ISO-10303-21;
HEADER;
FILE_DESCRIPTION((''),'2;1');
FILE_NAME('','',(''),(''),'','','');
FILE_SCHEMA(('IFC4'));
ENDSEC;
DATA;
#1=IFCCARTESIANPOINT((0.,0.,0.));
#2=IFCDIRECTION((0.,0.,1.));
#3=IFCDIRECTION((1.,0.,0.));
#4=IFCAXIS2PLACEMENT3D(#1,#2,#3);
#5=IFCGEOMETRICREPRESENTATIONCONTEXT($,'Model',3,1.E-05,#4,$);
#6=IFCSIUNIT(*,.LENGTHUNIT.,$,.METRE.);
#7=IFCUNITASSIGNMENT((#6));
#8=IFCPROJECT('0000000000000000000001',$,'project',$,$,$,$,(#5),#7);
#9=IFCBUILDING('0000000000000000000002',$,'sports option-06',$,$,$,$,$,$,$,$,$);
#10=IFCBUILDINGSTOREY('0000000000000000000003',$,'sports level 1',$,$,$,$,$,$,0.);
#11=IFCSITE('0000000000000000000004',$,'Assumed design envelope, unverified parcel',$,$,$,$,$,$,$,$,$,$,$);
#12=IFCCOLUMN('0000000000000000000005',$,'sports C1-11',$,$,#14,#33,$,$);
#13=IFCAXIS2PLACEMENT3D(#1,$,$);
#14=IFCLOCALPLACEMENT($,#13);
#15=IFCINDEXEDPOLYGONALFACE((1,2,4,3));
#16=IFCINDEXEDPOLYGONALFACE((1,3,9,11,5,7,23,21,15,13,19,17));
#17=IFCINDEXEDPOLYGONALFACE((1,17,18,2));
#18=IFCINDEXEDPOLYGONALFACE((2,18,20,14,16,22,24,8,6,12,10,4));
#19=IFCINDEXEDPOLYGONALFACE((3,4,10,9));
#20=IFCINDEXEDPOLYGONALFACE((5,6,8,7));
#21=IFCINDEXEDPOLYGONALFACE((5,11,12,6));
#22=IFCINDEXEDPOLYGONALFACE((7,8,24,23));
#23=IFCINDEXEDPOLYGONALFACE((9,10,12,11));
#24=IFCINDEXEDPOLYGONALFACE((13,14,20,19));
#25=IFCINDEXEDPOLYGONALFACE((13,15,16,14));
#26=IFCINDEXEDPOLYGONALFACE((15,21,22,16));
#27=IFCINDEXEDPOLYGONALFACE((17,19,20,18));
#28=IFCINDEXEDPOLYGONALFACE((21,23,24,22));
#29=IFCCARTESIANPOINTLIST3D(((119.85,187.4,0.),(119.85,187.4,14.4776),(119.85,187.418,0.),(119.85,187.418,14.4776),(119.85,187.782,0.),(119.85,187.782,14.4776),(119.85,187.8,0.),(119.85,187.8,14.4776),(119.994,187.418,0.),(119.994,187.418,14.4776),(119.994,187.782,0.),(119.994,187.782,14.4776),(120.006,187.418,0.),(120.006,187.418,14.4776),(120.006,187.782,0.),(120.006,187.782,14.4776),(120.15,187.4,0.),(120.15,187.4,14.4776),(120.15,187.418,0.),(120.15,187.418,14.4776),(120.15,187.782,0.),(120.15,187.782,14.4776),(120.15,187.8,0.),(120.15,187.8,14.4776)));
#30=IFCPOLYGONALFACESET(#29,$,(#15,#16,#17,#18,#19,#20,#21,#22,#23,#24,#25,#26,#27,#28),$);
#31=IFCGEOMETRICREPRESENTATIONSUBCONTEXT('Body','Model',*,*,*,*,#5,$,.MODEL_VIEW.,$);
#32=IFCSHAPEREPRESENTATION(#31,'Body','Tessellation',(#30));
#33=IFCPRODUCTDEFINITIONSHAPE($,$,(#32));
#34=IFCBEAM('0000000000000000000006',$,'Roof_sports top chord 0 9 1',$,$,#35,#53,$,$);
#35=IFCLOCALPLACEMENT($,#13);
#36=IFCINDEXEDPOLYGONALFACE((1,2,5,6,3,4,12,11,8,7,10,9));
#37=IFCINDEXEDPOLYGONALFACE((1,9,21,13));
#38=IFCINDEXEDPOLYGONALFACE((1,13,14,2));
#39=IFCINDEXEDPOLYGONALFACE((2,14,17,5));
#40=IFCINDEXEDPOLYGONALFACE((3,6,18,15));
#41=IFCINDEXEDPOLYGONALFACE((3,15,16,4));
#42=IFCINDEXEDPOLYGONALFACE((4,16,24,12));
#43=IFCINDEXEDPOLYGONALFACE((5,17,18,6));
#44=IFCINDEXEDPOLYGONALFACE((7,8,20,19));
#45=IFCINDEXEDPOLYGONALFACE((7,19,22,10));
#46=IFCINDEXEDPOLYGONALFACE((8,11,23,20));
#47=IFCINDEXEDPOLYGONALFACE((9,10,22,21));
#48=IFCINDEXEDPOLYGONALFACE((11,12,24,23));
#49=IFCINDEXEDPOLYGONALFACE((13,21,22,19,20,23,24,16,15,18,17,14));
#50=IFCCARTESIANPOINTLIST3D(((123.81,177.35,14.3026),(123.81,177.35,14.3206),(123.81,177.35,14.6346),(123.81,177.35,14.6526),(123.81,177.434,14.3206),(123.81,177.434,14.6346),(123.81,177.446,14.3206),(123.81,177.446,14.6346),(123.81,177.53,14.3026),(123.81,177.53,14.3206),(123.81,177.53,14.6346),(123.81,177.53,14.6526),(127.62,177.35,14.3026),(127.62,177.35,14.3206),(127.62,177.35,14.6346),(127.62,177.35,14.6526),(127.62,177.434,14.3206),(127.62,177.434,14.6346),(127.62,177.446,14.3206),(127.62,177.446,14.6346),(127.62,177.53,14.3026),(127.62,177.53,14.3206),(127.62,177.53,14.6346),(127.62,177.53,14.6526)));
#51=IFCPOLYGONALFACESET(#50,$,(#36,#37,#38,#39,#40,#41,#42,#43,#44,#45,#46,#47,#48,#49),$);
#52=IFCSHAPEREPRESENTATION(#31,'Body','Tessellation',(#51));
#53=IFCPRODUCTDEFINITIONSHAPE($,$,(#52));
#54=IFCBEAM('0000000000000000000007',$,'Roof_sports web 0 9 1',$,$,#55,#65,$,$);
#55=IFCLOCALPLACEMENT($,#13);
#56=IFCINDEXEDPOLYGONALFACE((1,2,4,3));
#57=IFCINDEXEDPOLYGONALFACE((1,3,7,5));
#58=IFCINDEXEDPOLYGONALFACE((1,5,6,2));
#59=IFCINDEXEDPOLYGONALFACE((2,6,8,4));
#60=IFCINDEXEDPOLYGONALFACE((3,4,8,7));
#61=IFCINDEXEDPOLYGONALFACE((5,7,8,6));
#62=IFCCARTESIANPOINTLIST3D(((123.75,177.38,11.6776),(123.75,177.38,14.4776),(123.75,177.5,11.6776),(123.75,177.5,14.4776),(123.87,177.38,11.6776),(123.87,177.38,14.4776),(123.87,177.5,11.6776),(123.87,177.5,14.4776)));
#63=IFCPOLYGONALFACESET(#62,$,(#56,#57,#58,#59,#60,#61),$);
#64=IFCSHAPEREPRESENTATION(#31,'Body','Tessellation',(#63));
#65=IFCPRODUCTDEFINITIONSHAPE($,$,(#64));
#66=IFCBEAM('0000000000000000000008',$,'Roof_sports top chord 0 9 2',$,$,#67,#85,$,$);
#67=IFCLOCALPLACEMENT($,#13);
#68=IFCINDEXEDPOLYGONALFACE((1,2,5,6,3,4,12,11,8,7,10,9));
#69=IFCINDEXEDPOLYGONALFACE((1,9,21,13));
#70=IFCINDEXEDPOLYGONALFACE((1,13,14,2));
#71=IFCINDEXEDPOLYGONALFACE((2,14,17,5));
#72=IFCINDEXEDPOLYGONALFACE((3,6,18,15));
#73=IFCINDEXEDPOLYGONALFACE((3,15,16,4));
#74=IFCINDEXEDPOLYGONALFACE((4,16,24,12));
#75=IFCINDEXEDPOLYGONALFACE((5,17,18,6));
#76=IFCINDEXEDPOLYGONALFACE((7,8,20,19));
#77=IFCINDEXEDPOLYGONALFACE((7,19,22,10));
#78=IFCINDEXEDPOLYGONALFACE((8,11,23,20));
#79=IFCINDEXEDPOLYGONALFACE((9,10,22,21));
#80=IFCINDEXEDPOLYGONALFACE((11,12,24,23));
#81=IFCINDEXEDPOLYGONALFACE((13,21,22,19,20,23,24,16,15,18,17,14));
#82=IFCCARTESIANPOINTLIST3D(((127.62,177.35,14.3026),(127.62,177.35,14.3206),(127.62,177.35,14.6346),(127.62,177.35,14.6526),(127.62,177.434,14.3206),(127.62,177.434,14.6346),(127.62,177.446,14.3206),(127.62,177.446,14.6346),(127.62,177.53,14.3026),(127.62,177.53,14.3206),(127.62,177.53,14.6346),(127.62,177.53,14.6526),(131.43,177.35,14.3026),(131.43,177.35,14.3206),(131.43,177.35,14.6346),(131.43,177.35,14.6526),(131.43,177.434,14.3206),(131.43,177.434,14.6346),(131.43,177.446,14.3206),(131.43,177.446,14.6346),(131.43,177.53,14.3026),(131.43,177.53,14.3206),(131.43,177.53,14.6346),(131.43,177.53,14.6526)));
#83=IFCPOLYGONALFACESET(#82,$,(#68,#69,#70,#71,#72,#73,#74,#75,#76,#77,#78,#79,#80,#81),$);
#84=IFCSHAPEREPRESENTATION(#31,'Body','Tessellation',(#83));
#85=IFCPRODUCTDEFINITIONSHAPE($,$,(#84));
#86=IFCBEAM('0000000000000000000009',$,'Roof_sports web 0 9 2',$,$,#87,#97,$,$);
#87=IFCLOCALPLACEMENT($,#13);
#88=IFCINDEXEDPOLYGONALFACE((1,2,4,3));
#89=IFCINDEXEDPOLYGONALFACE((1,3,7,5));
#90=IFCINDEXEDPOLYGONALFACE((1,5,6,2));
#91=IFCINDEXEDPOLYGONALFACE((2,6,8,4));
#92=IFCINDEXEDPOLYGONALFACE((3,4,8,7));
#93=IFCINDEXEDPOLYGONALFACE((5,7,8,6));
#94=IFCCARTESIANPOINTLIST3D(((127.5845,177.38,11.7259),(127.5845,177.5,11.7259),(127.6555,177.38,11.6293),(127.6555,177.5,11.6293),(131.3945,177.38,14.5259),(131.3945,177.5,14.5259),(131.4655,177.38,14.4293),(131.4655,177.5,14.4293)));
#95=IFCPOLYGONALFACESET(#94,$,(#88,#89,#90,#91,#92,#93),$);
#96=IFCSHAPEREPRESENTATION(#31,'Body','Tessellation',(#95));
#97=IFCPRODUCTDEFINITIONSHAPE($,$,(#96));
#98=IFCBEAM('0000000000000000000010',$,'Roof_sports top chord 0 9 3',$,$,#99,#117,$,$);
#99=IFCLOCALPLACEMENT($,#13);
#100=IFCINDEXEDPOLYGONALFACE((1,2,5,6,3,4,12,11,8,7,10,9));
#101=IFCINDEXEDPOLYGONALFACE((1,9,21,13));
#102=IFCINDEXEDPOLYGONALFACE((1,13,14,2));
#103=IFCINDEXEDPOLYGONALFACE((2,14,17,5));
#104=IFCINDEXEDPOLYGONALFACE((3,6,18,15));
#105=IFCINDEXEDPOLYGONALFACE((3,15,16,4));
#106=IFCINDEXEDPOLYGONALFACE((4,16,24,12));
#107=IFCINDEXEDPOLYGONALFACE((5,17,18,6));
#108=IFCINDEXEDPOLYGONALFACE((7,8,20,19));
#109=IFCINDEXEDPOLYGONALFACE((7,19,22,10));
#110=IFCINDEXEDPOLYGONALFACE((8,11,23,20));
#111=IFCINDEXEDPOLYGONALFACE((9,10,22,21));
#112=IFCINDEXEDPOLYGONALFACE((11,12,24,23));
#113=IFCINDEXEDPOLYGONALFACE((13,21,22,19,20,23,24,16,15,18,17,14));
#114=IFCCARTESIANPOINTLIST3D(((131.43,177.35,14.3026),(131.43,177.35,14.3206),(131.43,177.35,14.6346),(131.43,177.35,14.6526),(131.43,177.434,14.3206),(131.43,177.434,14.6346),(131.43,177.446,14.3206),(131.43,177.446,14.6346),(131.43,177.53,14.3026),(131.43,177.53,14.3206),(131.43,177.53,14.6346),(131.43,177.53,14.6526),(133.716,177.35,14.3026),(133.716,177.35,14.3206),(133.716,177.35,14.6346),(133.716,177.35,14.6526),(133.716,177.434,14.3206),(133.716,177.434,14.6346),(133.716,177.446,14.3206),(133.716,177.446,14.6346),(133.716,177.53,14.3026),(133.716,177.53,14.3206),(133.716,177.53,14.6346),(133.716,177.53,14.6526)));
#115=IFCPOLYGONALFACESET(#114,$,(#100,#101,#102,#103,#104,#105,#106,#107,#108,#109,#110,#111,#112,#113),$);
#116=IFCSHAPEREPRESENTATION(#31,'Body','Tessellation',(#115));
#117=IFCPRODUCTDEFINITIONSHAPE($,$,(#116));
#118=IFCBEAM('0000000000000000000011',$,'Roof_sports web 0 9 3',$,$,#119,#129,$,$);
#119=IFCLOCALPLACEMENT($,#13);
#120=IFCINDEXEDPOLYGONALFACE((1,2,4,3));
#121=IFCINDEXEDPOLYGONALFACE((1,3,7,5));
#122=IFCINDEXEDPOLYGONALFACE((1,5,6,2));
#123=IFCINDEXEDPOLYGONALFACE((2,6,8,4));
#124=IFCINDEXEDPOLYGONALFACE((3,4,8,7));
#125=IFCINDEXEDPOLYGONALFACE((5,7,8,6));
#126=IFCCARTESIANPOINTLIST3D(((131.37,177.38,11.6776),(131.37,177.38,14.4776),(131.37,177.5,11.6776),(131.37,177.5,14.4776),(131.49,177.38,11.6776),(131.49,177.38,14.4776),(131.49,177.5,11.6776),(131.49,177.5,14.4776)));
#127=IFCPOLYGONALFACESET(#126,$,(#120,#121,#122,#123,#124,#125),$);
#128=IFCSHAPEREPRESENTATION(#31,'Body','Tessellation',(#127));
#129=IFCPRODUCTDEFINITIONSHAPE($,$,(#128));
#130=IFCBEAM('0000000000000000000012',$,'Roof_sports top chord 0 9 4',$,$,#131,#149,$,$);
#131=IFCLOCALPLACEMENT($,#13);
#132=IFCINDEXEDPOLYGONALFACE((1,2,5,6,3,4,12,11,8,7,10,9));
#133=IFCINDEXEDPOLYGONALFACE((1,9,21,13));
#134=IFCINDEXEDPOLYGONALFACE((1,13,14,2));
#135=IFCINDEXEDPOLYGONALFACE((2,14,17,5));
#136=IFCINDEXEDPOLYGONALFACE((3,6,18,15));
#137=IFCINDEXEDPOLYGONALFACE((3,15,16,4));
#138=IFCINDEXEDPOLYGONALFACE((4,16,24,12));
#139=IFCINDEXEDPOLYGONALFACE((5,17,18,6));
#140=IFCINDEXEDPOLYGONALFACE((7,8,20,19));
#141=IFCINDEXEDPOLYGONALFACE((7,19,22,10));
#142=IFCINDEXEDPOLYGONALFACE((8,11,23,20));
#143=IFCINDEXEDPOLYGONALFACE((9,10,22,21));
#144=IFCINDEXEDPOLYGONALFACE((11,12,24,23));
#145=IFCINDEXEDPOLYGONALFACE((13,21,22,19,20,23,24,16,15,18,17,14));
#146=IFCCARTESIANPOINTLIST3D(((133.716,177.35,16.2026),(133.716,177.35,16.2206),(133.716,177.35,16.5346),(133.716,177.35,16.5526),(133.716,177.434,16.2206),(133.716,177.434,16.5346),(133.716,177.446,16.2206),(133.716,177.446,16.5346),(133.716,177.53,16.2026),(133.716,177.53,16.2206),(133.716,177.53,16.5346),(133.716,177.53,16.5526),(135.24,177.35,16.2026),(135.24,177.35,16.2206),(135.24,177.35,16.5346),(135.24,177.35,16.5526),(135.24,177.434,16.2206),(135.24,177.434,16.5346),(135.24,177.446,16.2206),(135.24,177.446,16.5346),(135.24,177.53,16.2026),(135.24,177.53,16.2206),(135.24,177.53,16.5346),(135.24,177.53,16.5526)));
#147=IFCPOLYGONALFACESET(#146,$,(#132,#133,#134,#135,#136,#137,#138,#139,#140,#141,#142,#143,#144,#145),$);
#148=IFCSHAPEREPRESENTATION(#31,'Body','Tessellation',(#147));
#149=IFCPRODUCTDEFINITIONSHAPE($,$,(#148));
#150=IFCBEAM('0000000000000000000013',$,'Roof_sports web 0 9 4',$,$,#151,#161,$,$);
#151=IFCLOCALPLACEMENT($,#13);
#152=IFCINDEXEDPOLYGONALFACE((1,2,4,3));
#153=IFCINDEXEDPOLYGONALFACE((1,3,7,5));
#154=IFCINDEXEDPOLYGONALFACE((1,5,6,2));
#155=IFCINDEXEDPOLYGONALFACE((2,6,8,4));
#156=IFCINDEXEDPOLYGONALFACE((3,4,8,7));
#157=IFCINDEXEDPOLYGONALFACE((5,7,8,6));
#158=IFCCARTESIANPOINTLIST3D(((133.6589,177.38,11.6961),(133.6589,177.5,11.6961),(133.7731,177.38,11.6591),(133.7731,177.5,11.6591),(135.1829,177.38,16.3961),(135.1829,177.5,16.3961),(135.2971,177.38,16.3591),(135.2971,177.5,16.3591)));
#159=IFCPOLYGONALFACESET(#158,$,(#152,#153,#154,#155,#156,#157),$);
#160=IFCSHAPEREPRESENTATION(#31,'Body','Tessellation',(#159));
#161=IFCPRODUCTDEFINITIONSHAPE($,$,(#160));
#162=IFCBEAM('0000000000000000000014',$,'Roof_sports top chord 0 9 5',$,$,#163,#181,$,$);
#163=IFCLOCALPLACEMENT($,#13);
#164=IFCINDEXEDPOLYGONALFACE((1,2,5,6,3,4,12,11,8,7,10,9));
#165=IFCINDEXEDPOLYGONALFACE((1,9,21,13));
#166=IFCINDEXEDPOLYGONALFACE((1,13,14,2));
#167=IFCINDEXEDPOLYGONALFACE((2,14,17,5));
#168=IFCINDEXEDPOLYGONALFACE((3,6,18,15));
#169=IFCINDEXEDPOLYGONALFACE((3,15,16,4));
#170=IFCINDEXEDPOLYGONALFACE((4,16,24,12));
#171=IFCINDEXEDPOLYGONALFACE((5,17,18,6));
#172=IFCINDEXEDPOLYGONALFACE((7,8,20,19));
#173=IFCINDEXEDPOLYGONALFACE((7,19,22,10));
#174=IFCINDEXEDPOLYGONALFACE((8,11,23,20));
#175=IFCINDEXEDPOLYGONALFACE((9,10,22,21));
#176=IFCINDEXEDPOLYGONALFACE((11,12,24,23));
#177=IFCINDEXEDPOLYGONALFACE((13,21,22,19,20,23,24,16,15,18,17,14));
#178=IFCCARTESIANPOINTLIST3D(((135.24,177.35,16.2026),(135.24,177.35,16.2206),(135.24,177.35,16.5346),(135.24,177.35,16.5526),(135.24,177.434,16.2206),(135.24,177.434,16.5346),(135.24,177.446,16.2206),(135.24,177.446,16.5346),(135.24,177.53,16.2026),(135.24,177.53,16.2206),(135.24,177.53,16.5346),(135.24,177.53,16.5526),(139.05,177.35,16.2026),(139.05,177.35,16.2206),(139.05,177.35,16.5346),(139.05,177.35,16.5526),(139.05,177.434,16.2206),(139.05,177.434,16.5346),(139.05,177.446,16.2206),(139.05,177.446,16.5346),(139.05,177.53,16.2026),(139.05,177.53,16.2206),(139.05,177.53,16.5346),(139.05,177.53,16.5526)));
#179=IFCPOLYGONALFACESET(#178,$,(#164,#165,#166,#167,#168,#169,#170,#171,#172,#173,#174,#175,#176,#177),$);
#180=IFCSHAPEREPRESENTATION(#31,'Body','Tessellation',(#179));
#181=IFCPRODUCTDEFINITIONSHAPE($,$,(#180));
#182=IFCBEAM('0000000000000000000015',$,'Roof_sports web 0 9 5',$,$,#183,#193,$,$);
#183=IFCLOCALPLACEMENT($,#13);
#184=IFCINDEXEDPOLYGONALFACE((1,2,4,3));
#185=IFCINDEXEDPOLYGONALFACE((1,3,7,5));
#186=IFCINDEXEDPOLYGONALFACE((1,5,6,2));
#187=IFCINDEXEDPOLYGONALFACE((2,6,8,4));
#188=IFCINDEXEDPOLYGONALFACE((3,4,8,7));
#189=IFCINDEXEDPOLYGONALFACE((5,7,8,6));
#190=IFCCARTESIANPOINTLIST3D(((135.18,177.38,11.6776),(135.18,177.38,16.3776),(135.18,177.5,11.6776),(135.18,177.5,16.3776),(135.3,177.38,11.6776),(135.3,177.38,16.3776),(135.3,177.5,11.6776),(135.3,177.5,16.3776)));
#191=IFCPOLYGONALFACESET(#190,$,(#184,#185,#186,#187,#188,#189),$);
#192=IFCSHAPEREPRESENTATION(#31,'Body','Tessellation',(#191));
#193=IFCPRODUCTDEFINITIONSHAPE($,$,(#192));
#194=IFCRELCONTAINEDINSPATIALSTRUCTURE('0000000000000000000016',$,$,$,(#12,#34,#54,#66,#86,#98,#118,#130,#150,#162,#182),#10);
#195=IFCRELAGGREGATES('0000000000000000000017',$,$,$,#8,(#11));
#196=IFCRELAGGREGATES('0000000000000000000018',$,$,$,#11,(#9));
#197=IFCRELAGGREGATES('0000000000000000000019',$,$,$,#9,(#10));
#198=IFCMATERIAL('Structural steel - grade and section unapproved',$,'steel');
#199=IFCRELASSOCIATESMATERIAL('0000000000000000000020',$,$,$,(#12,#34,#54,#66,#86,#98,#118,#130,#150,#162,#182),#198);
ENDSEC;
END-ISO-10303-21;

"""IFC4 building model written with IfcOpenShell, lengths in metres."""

from ifc_helpers import new_model, si_unit, frame, origin_with_axes, place, context, subcontext, project, spatial, rectangle, i_section, extrude, material, element, save


model = new_model("IFC4")

# Units and contexts
model_context = context("Model", 3, precision=1e-05, world=origin_with_axes())
body_context = subcontext(model_context, "Body", "Model", "MODEL_VIEW")
ifc_project = project(units=[si_unit("LENGTHUNIT", "METRE")], contexts=[model_context])

# Site, building, storey
site = spatial("IfcSite", under=ifc_project, Name="Assumed design envelope, unverified parcel")
building = spatial("IfcBuilding", under=site, Name="sports option-06")
storey = spatial("IfcBuildingStorey", under=building, Name="sports level 1", Elevation=0.0)

# Column
ifc_material_1 = material(Name="Structural steel - grade and section unapproved", Category="steel")
column_placement = place(None, frame((120.0, 187.6, 0.0), z_axis=(0.0, 0.0, 1.0), x_axis=(-1.0, 0.0, 0.0)))
element("IfcColumn", 1, at=column_placement, inside=storey, material=ifc_material_1, Name="sports C1-11", context=body_context, shape_type="SweptSolid", body=[
    extrude(i_section(OverallWidth=0.3, OverallDepth=0.4, WebThickness=0.012, FlangeThickness=0.018, FilletRadius=0.0), origin_with_axes(), (0.0, 0.0, 1.0), 14.4776),
])

# Beams
beam_1_placement = place(None, frame((123.81, 177.44, 14.4776), z_axis=(1.0, 0.0, 0.0), x_axis=(0.0, 1.0, 0.0)))
element("IfcBeam", 2, at=beam_1_placement, inside=storey, material=ifc_material_1, Name="Roof_sports top chord 0 9 1", context=body_context, shape_type="SweptSolid", body=[
    extrude(i_section(OverallWidth=0.18, OverallDepth=0.35, WebThickness=0.012, FlangeThickness=0.018, FilletRadius=0.0), origin_with_axes(), (0.0, 0.0, 1.0), 3.81),
])
beam_2_placement = place(None, frame((123.81, 177.44, 11.6776), z_axis=(0.0, 0.0, 1.0), x_axis=(-1.0, 0.0, 0.0)))
element("IfcBeam", 3, at=beam_2_placement, inside=storey, material=ifc_material_1, Name="Roof_sports web 0 9 1", context=body_context, shape_type="SweptSolid", body=[
    extrude(rectangle(XDim=0.12, YDim=0.12), origin_with_axes(), (0.0, 0.0, 1.0), 2.8),
])
beam_3_placement = place(None, frame((127.62, 177.44, 14.4776), z_axis=(1.0, 0.0, 0.0), x_axis=(0.0, 1.0, 0.0)))
element("IfcBeam", 4, at=beam_3_placement, inside=storey, material=ifc_material_1, Name="Roof_sports top chord 0 9 2", context=body_context, shape_type="SweptSolid", body=[
    extrude(i_section(OverallWidth=0.18, OverallDepth=0.35, WebThickness=0.012, FlangeThickness=0.018, FilletRadius=0.0), origin_with_axes(), (0.0, 0.0, 1.0), 3.81),
])
beam_4_placement = place(None, frame((127.62, 177.44, 11.6776), z_axis=(0.805799, 0.0, 0.59219), x_axis=(0.0, 1.0, 0.0)))
element("IfcBeam", 5, at=beam_4_placement, inside=storey, material=ifc_material_1, Name="Roof_sports web 0 9 2", context=body_context, shape_type="SweptSolid", body=[
    extrude(rectangle(XDim=0.12, YDim=0.12), origin_with_axes(), (0.0, 0.0, 1.0), 4.7282),
])
beam_5_placement = place(None, frame((131.43, 177.44, 14.4776), z_axis=(1.0, 0.0, 0.0), x_axis=(0.0, 1.0, 0.0)))
element("IfcBeam", 6, at=beam_5_placement, inside=storey, material=ifc_material_1, Name="Roof_sports top chord 0 9 3", context=body_context, shape_type="SweptSolid", body=[
    extrude(i_section(OverallWidth=0.18, OverallDepth=0.35, WebThickness=0.012, FlangeThickness=0.018, FilletRadius=0.0), origin_with_axes(), (0.0, 0.0, 1.0), 2.286),
])
beam_6_placement = place(None, frame((131.43, 177.44, 11.6776), z_axis=(0.0, 0.0, 1.0), x_axis=(-1.0, 0.0, 0.0)))
element("IfcBeam", 7, at=beam_6_placement, inside=storey, material=ifc_material_1, Name="Roof_sports web 0 9 3", context=body_context, shape_type="SweptSolid", body=[
    extrude(rectangle(XDim=0.12, YDim=0.12), origin_with_axes(), (0.0, 0.0, 1.0), 2.8),
])
beam_7_placement = place(None, frame((133.716, 177.44, 16.3776), z_axis=(1.0, 0.0, 0.0), x_axis=(0.0, 1.0, 0.0)))
element("IfcBeam", 8, at=beam_7_placement, inside=storey, material=ifc_material_1, Name="Roof_sports top chord 0 9 4", context=body_context, shape_type="SweptSolid", body=[
    extrude(i_section(OverallWidth=0.18, OverallDepth=0.35, WebThickness=0.012, FlangeThickness=0.018, FilletRadius=0.0), origin_with_axes(), (0.0, 0.0, 1.0), 1.524),
])
beam_8_placement = place(None, frame((133.716, 177.44, 11.6776), z_axis=(0.308446, 0.0, 0.951242), x_axis=(0.0, 1.0, 0.0)))
element("IfcBeam", 9, at=beam_8_placement, inside=storey, material=ifc_material_1, Name="Roof_sports web 0 9 4", context=body_context, shape_type="SweptSolid", body=[
    extrude(rectangle(XDim=0.12, YDim=0.12), origin_with_axes(), (0.0, 0.0, 1.0), 4.9409),
])
beam_9_placement = place(None, frame((135.24, 177.44, 16.3776), z_axis=(1.0, 0.0, 0.0), x_axis=(0.0, 1.0, 0.0)))
element("IfcBeam", 10, at=beam_9_placement, inside=storey, material=ifc_material_1, Name="Roof_sports top chord 0 9 5", context=body_context, shape_type="SweptSolid", body=[
    extrude(i_section(OverallWidth=0.18, OverallDepth=0.35, WebThickness=0.012, FlangeThickness=0.018, FilletRadius=0.0), origin_with_axes(), (0.0, 0.0, 1.0), 3.81),
])
beam_10_placement = place(None, frame((135.24, 177.44, 11.6776), z_axis=(0.0, 0.0, 1.0), x_axis=(-1.0, 0.0, 0.0)))
element("IfcBeam", 11, at=beam_10_placement, inside=storey, material=ifc_material_1, Name="Roof_sports web 0 9 5", context=body_context, shape_type="SweptSolid", body=[
    extrude(rectangle(XDim=0.12, YDim=0.12), origin_with_axes(), (0.0, 0.0, 1.0), 4.7),
])

save(model, "model.ifc")
